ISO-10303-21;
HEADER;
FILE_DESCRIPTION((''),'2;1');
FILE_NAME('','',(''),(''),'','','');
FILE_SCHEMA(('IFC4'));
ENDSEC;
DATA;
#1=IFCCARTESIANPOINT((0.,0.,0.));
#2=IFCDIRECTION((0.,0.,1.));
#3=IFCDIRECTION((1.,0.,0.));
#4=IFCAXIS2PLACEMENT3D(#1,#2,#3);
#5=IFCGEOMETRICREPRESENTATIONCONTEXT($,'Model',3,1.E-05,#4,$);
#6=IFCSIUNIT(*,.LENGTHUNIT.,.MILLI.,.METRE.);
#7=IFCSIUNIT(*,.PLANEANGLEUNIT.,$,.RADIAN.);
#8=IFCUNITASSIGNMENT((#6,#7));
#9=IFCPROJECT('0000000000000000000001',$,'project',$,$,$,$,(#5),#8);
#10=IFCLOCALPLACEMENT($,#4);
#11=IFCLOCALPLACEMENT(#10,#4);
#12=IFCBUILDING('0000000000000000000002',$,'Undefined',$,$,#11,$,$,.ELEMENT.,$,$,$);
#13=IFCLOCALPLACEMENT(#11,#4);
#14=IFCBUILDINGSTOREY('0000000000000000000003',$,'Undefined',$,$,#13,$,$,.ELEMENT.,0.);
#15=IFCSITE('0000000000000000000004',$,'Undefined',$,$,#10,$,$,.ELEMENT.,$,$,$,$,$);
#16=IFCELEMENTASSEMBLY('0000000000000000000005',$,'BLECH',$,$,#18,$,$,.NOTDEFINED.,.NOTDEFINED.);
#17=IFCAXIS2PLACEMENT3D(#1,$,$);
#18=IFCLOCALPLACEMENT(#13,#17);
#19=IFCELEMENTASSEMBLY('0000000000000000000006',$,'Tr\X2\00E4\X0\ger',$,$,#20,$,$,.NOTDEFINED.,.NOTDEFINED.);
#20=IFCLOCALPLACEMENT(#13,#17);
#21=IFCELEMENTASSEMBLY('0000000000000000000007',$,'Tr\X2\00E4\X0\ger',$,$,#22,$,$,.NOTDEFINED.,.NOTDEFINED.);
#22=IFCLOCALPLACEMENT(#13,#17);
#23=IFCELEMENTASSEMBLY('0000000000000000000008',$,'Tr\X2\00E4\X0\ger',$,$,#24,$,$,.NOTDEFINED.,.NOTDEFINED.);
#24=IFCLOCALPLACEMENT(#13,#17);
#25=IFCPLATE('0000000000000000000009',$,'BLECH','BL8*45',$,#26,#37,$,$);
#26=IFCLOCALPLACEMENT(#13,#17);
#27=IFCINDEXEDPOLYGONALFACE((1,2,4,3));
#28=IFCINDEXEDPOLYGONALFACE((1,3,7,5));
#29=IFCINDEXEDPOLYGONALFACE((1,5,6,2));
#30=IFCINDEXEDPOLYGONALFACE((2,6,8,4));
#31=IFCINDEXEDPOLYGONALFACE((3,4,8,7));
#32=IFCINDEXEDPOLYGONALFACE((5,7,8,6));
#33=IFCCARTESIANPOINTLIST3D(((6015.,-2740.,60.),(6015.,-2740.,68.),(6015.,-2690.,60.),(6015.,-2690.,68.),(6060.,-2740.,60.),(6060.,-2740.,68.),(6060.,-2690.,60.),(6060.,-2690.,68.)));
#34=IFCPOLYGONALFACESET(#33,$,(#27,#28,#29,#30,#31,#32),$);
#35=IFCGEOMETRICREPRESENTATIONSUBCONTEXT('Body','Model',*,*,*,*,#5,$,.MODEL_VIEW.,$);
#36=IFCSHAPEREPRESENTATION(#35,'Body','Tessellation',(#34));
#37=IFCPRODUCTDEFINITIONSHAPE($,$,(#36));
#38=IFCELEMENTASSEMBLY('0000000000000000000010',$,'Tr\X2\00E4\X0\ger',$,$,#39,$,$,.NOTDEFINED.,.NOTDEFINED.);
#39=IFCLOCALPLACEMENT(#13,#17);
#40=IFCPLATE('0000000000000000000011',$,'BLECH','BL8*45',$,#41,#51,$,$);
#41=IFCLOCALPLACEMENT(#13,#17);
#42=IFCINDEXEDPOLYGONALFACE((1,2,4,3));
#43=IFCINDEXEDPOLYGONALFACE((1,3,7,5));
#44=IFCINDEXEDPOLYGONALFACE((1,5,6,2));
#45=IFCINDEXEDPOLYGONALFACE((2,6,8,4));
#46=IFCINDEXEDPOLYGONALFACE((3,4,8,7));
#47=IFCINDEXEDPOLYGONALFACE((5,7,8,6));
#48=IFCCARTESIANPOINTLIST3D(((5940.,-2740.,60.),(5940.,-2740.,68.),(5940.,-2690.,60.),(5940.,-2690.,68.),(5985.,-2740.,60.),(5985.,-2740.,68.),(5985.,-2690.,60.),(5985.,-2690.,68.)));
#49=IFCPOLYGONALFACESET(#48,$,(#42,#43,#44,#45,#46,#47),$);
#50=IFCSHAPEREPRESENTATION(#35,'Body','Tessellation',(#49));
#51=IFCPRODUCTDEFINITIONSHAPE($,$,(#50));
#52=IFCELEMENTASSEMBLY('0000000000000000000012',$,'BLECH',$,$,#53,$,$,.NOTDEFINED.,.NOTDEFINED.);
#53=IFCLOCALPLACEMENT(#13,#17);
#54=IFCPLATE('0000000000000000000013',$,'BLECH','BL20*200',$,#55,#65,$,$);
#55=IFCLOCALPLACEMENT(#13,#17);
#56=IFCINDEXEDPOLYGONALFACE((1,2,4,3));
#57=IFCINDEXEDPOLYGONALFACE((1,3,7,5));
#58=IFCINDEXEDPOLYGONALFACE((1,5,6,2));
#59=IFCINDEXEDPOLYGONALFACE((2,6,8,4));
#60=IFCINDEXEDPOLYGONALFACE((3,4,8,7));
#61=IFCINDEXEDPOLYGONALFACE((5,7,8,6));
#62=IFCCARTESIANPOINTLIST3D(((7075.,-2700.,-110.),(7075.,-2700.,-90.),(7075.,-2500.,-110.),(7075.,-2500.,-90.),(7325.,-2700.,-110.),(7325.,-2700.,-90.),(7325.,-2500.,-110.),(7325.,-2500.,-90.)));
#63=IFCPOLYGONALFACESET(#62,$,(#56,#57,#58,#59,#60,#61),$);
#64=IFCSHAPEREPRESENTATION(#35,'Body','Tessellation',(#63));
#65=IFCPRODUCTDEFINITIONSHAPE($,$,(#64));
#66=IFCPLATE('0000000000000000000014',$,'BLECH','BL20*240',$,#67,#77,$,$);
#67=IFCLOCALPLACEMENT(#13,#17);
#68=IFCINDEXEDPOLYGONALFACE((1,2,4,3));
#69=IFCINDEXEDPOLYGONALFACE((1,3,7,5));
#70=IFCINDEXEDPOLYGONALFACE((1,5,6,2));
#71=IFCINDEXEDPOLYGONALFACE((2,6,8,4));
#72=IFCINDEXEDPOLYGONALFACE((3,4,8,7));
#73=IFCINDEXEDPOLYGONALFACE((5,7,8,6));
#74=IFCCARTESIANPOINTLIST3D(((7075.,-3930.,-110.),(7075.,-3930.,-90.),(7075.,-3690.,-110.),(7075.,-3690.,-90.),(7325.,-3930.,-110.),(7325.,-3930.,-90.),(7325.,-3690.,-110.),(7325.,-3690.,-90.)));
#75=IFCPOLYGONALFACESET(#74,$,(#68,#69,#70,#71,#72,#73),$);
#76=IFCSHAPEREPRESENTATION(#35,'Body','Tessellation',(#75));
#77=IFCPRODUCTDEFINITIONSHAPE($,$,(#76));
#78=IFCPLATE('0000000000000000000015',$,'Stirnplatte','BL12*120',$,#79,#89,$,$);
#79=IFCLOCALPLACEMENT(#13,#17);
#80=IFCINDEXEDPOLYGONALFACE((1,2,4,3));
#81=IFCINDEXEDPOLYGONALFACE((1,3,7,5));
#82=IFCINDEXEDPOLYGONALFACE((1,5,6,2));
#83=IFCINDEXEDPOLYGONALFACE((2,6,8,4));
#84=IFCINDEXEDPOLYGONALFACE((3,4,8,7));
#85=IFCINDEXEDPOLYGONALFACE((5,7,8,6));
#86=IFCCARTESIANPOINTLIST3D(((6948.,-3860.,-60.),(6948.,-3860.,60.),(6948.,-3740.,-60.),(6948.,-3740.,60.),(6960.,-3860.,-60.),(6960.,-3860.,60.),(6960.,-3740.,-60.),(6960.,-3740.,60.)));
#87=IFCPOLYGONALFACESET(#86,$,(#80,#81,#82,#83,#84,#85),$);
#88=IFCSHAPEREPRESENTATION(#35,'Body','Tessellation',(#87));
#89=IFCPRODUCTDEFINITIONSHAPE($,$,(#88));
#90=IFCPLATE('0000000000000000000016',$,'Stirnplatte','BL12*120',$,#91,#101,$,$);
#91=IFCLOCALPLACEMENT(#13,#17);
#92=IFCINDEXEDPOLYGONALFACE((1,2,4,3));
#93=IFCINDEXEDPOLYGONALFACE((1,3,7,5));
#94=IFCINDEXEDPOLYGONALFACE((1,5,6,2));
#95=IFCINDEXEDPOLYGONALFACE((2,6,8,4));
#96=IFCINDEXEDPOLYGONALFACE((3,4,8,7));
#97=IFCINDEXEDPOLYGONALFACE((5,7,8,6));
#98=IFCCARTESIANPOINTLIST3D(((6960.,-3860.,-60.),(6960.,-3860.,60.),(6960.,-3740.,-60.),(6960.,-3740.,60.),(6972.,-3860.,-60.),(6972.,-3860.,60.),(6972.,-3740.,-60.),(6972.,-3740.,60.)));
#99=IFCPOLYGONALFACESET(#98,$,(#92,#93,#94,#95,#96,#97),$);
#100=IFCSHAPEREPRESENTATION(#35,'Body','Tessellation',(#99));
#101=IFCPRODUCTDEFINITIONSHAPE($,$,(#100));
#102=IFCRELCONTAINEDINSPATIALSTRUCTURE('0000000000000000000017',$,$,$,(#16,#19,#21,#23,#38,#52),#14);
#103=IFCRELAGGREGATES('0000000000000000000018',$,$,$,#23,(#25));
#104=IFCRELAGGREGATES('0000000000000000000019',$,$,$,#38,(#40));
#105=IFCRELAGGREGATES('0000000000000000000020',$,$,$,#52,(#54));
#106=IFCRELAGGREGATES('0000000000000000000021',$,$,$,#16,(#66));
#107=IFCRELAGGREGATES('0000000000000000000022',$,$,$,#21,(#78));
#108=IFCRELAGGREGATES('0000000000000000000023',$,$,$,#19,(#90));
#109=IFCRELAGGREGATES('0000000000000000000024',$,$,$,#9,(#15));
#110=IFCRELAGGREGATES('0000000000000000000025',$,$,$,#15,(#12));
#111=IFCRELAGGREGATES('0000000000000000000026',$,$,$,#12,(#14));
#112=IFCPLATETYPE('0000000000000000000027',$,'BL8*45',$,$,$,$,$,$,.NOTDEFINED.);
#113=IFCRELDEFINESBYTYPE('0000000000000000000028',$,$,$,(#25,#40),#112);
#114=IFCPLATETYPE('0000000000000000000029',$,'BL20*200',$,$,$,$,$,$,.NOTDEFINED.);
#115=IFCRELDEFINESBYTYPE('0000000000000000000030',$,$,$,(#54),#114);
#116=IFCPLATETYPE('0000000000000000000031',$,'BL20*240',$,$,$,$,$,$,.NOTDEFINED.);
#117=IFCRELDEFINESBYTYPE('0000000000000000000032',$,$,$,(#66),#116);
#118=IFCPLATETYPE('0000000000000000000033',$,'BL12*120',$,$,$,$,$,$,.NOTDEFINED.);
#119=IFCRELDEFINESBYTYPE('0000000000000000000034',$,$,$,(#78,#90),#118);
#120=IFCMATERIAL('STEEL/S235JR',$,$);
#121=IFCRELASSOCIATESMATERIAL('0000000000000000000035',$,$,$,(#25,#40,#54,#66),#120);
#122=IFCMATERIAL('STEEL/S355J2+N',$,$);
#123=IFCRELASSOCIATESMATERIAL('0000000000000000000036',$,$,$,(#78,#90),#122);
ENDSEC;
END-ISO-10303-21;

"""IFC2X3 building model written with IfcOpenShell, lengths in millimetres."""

from ifc_helpers import new_model, si_unit, frame, origin_with_axes, place, context, subcontext, project, spatial, polyline, outline, extrude, material, type_object, element, aggregate, save


model = new_model("IFC2X3")

# Units and contexts
model_context = context("Model", 3, precision=1e-05, world=origin_with_axes())
body_context = subcontext(model_context, "Body", "Model", "MODEL_VIEW")
ifc_project = project(units=[si_unit("LENGTHUNIT", "METRE", prefix="MILLI"), si_unit("PLANEANGLEUNIT", "RADIAN")], contexts=[model_context])

# Site, building, storey
site_placement = place(None, origin_with_axes())
site = spatial("IfcSite", under=ifc_project, at=site_placement, Name="Undefined", CompositionType="ELEMENT")
building_placement = place(site_placement, origin_with_axes())
building = spatial("IfcBuilding", under=site, at=building_placement, Name="Undefined", CompositionType="ELEMENT")
storey_placement = place(building_placement, origin_with_axes())
storey = spatial("IfcBuildingStorey", under=building, at=storey_placement, Name="Undefined", CompositionType="ELEMENT", Elevation=0.0)

# Element assembly
assembly_1_placement = place(storey_placement, origin_with_axes())
assembly_1 = element("IfcElementAssembly", 1, at=assembly_1_placement, inside=storey, Name="BLECH", AssemblyPlace="NOTDEFINED", PredefinedType="NOTDEFINED")
ifc_material_1 = material(Name="STEEL/S235JR")

# Element assemblies
assembly_2_placement = place(storey_placement, origin_with_axes())
assembly_2 = element("IfcElementAssembly", 2, at=assembly_2_placement, inside=storey, Name="Träger", AssemblyPlace="NOTDEFINED", PredefinedType="NOTDEFINED")
assembly_3_placement = place(storey_placement, origin_with_axes())
assembly_3 = element("IfcElementAssembly", 3, at=assembly_3_placement, inside=storey, Name="Träger", AssemblyPlace="NOTDEFINED", PredefinedType="NOTDEFINED")

# Element assembly, plate
assembly_4_placement = place(storey_placement, origin_with_axes())
assembly_4 = element("IfcElementAssembly", 4, at=assembly_4_placement, inside=storey, Name="Träger", AssemblyPlace="NOTDEFINED", PredefinedType="NOTDEFINED")
plate_type_1 = type_object("IfcPlateType", Name="BL8*45", PredefinedType="NOTDEFINED")
plate_1_placement = place(assembly_4_placement, frame((6060.0, -2740.0, 64.0), z_axis=(0.0, 0.0, -1.0), x_axis=(-1.0, 0.0, 0.0)))
plate_1 = element("IfcPlate", 5, at=plate_1_placement, type_object=plate_type_1, material=ifc_material_1, Name="BLECH", Description="BL8*45", context=body_context, shape_type="SweptSolid", body=[
    extrude(outline(polyline([(0.0, 0.0), (45.0, 0.0), (45.0, 50.0), (0.0, 50.0), (0.0, 0.0)])), frame((0.0, 0.0, -4.0), z_axis=(0.0, 0.0, 1.0), x_axis=(1.0, 0.0, 0.0)), (0.0, 0.0, 1.0), 8.0),
])
aggregate(assembly_4, [plate_1])

# Element assembly, plate
assembly_5_placement = place(storey_placement, origin_with_axes())
assembly_5 = element("IfcElementAssembly", 6, at=assembly_5_placement, inside=storey, Name="Träger", AssemblyPlace="NOTDEFINED", PredefinedType="NOTDEFINED")
plate_2_placement = place(assembly_5_placement, frame((5940.0, -2740.0, 64.0), z_axis=(0.0, 0.0, 1.0), x_axis=(1.0, 0.0, 0.0)))
plate_2 = element("IfcPlate", 7, at=plate_2_placement, type_object=plate_type_1, material=ifc_material_1, Name="BLECH", Description="BL8*45", context=body_context, shape_type="SweptSolid", body=[
    extrude(outline(polyline([(0.0, 0.0), (45.0, 0.0), (45.0, 50.0), (0.0, 50.0), (0.0, 0.0)])), frame((0.0, 0.0, -4.0), z_axis=(0.0, 0.0, 1.0), x_axis=(1.0, 0.0, 0.0)), (0.0, 0.0, 1.0), 8.0),
])
aggregate(assembly_5, [plate_2])

# Shared definitions
ifc_material_2 = material(Name="STEEL/S355J2+N")

# Element assembly, plate
assembly_6_placement = place(storey_placement, origin_with_axes())
assembly_6 = element("IfcElementAssembly", 8, at=assembly_6_placement, inside=storey, Name="BLECH", AssemblyPlace="NOTDEFINED", PredefinedType="NOTDEFINED")
plate_type_2 = type_object("IfcPlateType", Name="BL20*200", PredefinedType="NOTDEFINED")
plate_3_placement = place(assembly_6_placement, frame((7075.0, -2700.0, -100.0), z_axis=(0.0, 0.0, 1.0), x_axis=(1.0, 0.0, 0.0)))
plate_3 = element("IfcPlate", 9, at=plate_3_placement, type_object=plate_type_2, material=ifc_material_1, Name="BLECH", Description="BL20*200", context=body_context, shape_type="SweptSolid", body=[
    extrude(outline(polyline([(0.0, 0.0), (250.0, 0.0), (250.0, 200.0), (0.0, 200.0), (0.0, 0.0)])), frame((0.0, 0.0, -10.0), z_axis=(0.0, 0.0, 1.0), x_axis=(1.0, 0.0, 0.0)), (0.0, 0.0, 1.0), 20.0),
])
aggregate(assembly_6, [plate_3])

# Plates
plate_type_3 = type_object("IfcPlateType", Name="BL20*240", PredefinedType="NOTDEFINED")
plate_4_placement = place(assembly_1_placement, frame((7075.0, -3930.0, -100.0), z_axis=(0.0, 0.0, 1.0), x_axis=(1.0, 0.0, 0.0)))
plate_4 = element("IfcPlate", 10, at=plate_4_placement, type_object=plate_type_3, material=ifc_material_1, Name="BLECH", Description="BL20*240", context=body_context, shape_type="SweptSolid", body=[
    extrude(outline(polyline([(0.0, 0.0), (250.0, 0.0), (250.0, 240.0), (0.0, 240.0), (0.0, 0.0)])), frame((0.0, 0.0, -10.0), z_axis=(0.0, 0.0, 1.0), x_axis=(1.0, 0.0, 0.0)), (0.0, 0.0, 1.0), 20.0),
])
aggregate(assembly_1, [plate_4])
plate_type_4 = type_object("IfcPlateType", Name="BL12*120", PredefinedType="NOTDEFINED")
plate_5_placement = place(assembly_3_placement, frame((6954.0, -3800.0, -60.0), z_axis=(-1.0, 0.0, 0.0), x_axis=(0.0, 0.0, 1.0)))
plate_5 = element("IfcPlate", 11, at=plate_5_placement, type_object=plate_type_4, material=ifc_material_2, Name="Stirnplatte", Description="BL12*120", context=body_context, shape_type="SweptSolid", body=[
    extrude(outline(polyline([(0.0, -60.0), (0.0, 60.0), (120.0, 60.0), (120.0, -60.0), (0.0, -60.0)])), frame((0.0, 0.0, -6.0), z_axis=(0.0, 0.0, 1.0), x_axis=(1.0, 0.0, 0.0)), (0.0, 0.0, 1.0), 12.0),
])
aggregate(assembly_3, [plate_5])
plate_6_placement = place(assembly_2_placement, frame((6966.0, -3800.0, -60.0), z_axis=(-1.0, 0.0, 0.0), x_axis=(0.0, 0.0, 1.0)))
plate_6 = element("IfcPlate", 12, at=plate_6_placement, type_object=plate_type_4, material=ifc_material_2, Name="Stirnplatte", Description="BL12*120", context=body_context, shape_type="SweptSolid", body=[
    extrude(outline(polyline([(0.0, -60.0), (0.0, 60.0), (120.0, 60.0), (120.0, -60.0), (0.0, -60.0)])), frame((0.0, 0.0, -6.0), z_axis=(0.0, 0.0, 1.0), x_axis=(1.0, 0.0, 0.0)), (0.0, 0.0, 1.0), 12.0),
])
aggregate(assembly_2, [plate_6])

save(model, "model.ifc")
